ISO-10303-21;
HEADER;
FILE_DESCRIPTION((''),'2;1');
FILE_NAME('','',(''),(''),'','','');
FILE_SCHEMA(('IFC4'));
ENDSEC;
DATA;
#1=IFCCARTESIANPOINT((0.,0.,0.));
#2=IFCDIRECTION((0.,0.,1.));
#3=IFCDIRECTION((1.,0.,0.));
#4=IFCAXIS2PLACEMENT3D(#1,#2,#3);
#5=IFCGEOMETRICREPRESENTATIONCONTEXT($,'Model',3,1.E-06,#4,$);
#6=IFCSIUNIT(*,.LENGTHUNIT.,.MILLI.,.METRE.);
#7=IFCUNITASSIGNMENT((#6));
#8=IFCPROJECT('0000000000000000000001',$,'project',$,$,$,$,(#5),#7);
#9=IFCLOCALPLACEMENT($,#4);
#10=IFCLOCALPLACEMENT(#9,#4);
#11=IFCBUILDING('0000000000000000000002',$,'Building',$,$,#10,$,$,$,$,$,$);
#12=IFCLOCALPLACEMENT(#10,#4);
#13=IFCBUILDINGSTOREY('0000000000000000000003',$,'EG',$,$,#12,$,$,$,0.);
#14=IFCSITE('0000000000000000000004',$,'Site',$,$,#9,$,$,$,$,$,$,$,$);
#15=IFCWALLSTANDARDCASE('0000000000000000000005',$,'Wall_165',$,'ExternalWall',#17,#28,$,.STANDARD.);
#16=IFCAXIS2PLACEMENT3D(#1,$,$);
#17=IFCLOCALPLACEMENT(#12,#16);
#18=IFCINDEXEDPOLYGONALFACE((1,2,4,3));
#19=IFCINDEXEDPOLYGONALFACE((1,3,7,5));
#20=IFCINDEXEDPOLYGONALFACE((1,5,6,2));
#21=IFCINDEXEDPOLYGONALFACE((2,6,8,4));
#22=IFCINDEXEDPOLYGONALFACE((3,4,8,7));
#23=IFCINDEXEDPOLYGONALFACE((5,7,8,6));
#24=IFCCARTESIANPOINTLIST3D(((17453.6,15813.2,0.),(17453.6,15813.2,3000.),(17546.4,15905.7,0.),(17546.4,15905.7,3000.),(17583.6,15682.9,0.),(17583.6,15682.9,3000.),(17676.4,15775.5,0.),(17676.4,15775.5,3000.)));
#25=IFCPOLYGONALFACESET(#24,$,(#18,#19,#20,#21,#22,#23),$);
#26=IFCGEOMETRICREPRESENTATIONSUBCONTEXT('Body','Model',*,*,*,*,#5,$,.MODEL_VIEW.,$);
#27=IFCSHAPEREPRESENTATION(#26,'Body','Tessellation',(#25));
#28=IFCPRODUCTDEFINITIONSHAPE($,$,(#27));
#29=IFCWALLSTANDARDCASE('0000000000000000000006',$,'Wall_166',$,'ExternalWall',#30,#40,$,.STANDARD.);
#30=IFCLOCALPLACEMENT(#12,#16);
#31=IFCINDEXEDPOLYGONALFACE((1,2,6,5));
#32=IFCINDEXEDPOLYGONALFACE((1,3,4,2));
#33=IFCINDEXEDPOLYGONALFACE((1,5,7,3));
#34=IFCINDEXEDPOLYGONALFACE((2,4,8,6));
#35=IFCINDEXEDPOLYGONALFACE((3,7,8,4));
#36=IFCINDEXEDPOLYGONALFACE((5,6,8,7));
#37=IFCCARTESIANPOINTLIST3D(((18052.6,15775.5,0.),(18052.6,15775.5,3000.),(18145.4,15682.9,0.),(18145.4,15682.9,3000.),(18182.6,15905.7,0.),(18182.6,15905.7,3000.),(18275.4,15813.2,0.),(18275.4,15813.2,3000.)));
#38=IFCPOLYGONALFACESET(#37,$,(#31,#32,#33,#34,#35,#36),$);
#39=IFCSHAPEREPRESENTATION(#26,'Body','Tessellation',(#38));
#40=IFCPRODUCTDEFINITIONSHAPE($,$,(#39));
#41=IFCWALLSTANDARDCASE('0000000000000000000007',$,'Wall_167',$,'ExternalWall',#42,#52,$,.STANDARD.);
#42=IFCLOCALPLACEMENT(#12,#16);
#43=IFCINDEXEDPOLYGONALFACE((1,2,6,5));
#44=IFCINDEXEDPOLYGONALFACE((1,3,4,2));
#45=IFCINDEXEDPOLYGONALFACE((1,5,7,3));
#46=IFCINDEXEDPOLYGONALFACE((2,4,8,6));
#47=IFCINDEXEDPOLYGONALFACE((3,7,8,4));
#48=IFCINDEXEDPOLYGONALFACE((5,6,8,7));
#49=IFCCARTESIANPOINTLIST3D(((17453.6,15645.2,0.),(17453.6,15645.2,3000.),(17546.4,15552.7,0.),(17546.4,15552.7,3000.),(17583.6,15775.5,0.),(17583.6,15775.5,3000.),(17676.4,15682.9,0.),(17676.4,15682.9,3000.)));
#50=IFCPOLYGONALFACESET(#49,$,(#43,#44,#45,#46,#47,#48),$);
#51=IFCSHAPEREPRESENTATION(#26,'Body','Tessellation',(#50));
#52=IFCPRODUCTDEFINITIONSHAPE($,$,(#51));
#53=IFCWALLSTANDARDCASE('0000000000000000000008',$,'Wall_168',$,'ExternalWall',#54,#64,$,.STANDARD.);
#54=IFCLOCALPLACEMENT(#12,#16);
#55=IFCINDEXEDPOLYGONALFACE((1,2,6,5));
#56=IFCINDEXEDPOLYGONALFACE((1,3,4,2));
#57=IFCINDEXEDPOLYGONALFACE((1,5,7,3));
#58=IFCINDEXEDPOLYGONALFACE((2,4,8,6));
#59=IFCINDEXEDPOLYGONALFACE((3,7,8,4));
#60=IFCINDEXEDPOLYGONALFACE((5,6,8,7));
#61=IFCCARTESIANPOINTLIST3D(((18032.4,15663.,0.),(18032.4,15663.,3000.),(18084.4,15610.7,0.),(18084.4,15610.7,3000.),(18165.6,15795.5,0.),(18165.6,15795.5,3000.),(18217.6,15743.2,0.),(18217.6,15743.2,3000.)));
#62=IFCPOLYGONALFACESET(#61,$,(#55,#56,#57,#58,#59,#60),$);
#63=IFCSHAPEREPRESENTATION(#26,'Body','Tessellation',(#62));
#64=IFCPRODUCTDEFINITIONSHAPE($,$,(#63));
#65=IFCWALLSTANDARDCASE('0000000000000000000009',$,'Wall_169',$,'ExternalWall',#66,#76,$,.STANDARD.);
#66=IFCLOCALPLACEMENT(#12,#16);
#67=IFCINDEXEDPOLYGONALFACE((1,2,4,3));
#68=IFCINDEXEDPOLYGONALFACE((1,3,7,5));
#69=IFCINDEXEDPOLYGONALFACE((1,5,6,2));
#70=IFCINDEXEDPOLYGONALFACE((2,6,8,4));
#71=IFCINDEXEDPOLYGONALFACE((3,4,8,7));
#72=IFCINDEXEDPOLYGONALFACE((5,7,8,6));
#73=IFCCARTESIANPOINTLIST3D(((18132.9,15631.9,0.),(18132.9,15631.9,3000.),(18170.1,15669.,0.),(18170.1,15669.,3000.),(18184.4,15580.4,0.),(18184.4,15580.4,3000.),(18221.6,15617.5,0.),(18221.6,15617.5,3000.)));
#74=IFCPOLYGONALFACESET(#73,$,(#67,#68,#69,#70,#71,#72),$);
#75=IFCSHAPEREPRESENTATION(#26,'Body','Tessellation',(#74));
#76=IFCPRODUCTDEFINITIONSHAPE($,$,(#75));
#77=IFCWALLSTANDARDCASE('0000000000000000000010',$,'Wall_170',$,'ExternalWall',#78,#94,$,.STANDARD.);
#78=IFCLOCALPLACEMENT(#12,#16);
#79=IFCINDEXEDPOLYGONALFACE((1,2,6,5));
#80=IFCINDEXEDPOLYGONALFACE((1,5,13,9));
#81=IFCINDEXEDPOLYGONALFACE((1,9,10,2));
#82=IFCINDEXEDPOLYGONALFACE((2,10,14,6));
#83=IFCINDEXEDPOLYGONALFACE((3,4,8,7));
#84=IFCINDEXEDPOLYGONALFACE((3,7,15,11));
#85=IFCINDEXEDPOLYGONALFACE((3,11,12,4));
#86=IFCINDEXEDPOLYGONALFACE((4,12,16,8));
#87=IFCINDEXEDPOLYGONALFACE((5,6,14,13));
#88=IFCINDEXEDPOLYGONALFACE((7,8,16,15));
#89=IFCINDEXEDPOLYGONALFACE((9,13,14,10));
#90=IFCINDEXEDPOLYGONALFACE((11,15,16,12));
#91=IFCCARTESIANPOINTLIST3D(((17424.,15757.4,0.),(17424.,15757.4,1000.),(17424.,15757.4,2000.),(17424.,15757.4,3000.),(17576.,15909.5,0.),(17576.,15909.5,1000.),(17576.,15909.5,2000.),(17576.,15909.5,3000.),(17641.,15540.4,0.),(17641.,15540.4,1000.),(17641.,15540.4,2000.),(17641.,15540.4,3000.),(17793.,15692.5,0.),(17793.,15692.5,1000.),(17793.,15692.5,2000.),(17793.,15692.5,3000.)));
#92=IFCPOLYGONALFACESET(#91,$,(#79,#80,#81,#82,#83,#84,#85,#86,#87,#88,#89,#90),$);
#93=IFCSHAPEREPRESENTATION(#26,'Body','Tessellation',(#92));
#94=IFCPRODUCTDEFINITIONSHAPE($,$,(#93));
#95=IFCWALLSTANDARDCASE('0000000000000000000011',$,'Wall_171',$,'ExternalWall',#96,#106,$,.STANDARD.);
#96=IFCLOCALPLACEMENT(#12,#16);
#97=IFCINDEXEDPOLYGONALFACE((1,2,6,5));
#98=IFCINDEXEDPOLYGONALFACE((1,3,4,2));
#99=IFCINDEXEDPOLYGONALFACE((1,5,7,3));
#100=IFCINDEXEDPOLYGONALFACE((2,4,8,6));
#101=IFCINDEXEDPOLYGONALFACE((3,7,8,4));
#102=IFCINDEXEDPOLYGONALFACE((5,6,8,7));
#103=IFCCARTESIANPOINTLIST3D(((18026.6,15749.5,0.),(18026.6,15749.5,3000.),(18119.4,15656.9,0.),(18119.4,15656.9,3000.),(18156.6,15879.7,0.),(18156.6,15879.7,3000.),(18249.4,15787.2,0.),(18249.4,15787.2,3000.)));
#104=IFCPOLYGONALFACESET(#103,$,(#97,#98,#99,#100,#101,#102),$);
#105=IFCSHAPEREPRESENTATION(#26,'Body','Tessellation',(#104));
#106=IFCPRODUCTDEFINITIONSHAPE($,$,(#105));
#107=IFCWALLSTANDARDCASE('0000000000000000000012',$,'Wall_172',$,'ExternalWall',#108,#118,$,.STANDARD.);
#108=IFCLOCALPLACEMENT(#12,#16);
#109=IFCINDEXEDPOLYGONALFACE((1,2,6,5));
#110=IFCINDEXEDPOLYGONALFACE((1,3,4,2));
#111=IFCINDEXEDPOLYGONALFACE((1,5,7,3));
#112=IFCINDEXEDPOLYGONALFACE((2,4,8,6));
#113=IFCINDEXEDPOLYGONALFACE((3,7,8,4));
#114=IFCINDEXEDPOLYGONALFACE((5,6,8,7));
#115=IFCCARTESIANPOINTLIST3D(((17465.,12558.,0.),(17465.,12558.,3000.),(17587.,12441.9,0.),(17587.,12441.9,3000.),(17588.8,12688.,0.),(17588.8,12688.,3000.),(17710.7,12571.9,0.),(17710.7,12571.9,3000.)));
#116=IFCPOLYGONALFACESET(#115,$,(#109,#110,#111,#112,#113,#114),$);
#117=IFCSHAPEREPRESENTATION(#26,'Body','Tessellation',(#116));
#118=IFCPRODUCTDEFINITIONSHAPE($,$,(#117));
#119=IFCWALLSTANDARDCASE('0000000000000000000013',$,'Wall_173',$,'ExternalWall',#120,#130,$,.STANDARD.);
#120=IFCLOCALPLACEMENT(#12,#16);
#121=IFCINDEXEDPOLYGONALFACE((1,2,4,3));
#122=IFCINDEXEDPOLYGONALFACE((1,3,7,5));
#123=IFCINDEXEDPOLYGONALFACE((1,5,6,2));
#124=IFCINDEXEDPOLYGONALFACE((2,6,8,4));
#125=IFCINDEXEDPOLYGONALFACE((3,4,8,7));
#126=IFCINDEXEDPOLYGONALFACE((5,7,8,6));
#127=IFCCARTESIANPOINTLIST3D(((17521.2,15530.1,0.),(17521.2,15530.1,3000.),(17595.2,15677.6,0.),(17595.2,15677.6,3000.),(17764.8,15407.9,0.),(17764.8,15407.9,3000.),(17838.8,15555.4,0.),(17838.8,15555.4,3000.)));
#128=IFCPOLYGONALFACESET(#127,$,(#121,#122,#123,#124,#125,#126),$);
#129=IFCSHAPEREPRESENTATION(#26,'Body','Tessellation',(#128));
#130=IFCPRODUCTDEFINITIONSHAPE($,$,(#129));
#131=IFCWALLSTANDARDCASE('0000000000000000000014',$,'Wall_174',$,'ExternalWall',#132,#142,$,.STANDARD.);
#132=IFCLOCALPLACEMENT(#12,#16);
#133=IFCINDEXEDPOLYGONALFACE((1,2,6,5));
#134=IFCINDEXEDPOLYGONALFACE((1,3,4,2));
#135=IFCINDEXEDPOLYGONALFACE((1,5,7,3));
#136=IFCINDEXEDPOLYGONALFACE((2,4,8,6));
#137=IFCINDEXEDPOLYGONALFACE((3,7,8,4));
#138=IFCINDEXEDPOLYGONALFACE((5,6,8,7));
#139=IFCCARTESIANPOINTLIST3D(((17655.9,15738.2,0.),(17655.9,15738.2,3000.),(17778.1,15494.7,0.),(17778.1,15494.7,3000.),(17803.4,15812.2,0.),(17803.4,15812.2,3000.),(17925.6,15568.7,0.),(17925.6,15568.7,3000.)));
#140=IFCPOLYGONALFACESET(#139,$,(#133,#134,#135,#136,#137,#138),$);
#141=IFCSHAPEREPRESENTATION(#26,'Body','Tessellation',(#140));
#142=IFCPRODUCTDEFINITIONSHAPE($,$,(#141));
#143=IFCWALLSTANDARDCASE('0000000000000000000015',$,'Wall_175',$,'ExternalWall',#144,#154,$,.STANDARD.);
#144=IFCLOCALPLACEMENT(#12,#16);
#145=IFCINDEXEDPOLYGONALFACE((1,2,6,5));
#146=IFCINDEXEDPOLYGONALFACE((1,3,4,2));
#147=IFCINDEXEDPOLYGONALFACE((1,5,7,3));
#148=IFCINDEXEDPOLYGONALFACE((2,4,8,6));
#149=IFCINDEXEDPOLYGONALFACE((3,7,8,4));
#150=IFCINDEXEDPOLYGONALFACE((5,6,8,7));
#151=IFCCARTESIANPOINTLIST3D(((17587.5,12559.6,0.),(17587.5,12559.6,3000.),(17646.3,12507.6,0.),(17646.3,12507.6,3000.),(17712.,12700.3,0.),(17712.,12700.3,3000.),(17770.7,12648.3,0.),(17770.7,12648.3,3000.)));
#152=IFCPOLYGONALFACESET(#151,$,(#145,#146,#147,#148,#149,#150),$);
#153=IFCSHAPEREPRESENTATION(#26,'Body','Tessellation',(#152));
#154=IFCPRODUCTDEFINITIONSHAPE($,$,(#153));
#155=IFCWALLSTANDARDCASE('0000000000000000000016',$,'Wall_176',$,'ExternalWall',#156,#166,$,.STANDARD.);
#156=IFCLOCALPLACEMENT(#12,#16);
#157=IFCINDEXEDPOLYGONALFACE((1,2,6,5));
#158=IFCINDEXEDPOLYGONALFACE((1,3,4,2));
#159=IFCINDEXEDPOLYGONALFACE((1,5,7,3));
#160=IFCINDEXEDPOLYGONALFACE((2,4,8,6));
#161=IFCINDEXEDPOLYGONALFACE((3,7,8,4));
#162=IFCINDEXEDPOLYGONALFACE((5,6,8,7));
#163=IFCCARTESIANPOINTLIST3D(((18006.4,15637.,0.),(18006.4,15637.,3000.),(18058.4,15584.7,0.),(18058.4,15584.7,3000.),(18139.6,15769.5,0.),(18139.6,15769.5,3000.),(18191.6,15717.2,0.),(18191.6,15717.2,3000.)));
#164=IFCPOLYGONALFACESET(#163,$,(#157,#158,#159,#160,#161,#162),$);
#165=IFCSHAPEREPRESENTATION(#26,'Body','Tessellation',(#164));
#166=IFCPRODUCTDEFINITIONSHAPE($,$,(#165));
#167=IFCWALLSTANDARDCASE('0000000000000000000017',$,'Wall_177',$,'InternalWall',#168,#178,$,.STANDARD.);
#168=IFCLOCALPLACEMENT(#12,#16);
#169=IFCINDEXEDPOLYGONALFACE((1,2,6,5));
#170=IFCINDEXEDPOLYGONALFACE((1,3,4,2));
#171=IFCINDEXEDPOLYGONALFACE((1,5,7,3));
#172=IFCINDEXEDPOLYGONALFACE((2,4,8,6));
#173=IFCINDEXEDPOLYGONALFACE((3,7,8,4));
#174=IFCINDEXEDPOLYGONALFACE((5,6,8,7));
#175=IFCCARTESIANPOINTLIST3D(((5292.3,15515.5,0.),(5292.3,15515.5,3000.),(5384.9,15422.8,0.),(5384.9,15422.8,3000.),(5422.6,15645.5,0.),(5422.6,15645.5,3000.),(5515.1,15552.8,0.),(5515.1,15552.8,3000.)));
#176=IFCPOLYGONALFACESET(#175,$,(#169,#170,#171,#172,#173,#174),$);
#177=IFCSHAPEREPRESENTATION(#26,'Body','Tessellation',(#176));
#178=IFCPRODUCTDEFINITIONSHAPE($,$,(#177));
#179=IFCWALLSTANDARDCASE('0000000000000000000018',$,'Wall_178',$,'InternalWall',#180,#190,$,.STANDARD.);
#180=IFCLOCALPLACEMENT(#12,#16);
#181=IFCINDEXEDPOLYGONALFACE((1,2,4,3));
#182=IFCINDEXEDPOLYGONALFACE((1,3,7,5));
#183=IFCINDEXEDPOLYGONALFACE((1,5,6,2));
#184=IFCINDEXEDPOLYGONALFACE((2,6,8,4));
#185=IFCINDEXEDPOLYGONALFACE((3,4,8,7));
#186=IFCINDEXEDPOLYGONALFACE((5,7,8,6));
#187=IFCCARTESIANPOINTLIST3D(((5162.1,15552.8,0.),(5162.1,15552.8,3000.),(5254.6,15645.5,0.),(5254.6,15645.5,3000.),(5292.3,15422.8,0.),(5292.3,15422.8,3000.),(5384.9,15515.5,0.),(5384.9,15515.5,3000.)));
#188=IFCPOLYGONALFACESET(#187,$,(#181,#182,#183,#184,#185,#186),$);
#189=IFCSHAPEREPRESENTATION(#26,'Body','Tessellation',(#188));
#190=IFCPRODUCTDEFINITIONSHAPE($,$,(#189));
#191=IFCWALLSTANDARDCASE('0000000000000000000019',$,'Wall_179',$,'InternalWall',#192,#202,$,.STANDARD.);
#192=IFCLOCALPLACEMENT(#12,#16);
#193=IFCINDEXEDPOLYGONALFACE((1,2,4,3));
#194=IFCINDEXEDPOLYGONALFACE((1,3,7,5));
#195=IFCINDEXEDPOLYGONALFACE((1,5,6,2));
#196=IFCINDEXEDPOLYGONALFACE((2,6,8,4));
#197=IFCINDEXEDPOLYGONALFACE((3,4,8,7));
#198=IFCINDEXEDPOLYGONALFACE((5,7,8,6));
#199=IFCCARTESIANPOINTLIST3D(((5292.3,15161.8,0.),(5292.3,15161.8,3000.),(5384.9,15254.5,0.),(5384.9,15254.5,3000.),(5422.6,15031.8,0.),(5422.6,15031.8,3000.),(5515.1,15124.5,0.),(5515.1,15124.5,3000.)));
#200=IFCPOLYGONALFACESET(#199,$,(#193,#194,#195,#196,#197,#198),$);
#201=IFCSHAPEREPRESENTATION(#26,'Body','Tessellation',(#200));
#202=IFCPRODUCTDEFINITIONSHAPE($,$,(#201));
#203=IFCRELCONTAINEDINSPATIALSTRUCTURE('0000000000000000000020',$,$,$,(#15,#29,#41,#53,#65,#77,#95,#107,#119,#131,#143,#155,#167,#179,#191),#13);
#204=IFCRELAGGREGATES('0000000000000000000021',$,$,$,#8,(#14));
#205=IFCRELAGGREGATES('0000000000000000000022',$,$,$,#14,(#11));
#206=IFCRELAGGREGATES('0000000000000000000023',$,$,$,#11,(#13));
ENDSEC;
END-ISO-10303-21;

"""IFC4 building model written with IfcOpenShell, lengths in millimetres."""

from ifc_helpers import new_model, si_unit, frame, origin_with_axes, place, context, subcontext, project, spatial, rectangle, extrude, element, save


model = new_model("IFC4")

# Units and contexts
model_context = context("Model", 3, precision=1e-06, world=origin_with_axes())
body_context = subcontext(model_context, "Body", "Model", "MODEL_VIEW")
ifc_project = project(units=[si_unit("LENGTHUNIT", "METRE", prefix="MILLI")], contexts=[model_context])

# Site, building, storey
site_placement = place(None, origin_with_axes())
site = spatial("IfcSite", under=ifc_project, at=site_placement, Name="Site")
building_placement = place(site_placement, origin_with_axes())
building = spatial("IfcBuilding", under=site, at=building_placement, Name="Building")
storey_placement = place(building_placement, origin_with_axes())
storey = spatial("IfcBuildingStorey", under=building, at=storey_placement, Name="EG", Elevation=0.0)

# Walls
wall_1_placement = place(storey_placement, origin_with_axes())
element("IfcWallStandardCase", 1, at=wall_1_placement, inside=storey, Name="Wall_165", ObjectType="ExternalWall", PredefinedType="STANDARD", context=body_context, shape_type="SweptSolid", body=[
    extrude(rectangle(XDim=184.0, YDim=131.0), frame((17565.0, 15794.3, 0.0), z_axis=(0.0, 0.0, 1.0), x_axis=(0.706427, -0.707786, 0.0)), (0.0, 0.0, 1.0), 3000.0),
])
wall_2_placement = place(storey_placement, origin_with_axes())
element("IfcWallStandardCase", 2, at=wall_2_placement, inside=storey, Name="Wall_166", ObjectType="ExternalWall", PredefinedType="STANDARD", context=body_context, shape_type="SweptSolid", body=[
    extrude(rectangle(XDim=184.0, YDim=131.0), frame((18164.0, 15794.3, 0.0), z_axis=(0.0, 0.0, 1.0), x_axis=(0.706427, 0.707786, 0.0)), (0.0, 0.0, 1.0), 3000.0),
])
wall_3_placement = place(storey_placement, origin_with_axes())
element("IfcWallStandardCase", 3, at=wall_3_placement, inside=storey, Name="Wall_167", ObjectType="ExternalWall", PredefinedType="STANDARD", context=body_context, shape_type="SweptSolid", body=[
    extrude(rectangle(XDim=184.0, YDim=131.0), frame((17565.0, 15664.1, 0.0), z_axis=(0.0, 0.0, 1.0), x_axis=(-0.706427, -0.707786, 0.0)), (0.0, 0.0, 1.0), 3000.0),
])
wall_4_placement = place(storey_placement, origin_with_axes())
element("IfcWallStandardCase", 4, at=wall_4_placement, inside=storey, Name="Wall_168", ObjectType="ExternalWall", PredefinedType="STANDARD", context=body_context, shape_type="SweptSolid", body=[
    extrude(rectangle(XDim=73.7, YDim=187.8), frame((18125.0, 15703.1, 0.0), z_axis=(0.0, 0.0, 1.0), x_axis=(0.705409, -0.7088, 0.0)), (0.0, 0.0, 1.0), 3000.0),
])
wall_5_placement = place(storey_placement, origin_with_axes())
element("IfcWallStandardCase", 5, at=wall_5_placement, inside=storey, Name="Wall_169", ObjectType="ExternalWall", PredefinedType="STANDARD", context=body_context, shape_type="SweptSolid", body=[
    extrude(rectangle(XDim=72.8, YDim=52.5), frame((18177.3, 15624.7, 0.0), z_axis=(0.0, 0.0, 1.0), x_axis=(0.707107, -0.707107, 0.0)), (0.0, 0.0, 1.0), 3000.0),
])

# Wall, opening
wall_6_placement = place(storey_placement, origin_with_axes())
wall_6 = element("IfcWallStandardCase", 6, at=wall_6_placement, inside=storey, Name="Wall_170", ObjectType="ExternalWall", PredefinedType="STANDARD", context=body_context, shape_type="SweptSolid", body=[
    extrude(rectangle(XDim=306.9, YDim=215.0), frame((17608.5, 15725.0, 0.0), z_axis=(0.0, 0.0, 1.0), x_axis=(-0.707107, 0.707107, 0.0)), (0.0, 0.0, 1.0), 3000.0),
])
opening_placement = place(wall_6_placement, origin_with_axes())
element("IfcOpeningElement", 7, at=opening_placement, inside=storey, cuts=wall_6, context=body_context, shape_type="SweptSolid", body=[
    extrude(rectangle(XDim=600.0, YDim=215.0), frame((17545.6, 15787.9, 1000.0), z_axis=(0.0, 0.0, 1.0), x_axis=(-0.707107, 0.707107, 0.0)), (0.0, 0.0, 1.0), 1000.0),
])

# Walls
wall_7_placement = place(storey_placement, origin_with_axes())
element("IfcWallStandardCase", 8, at=wall_7_placement, inside=storey, Name="Wall_171", ObjectType="ExternalWall", PredefinedType="STANDARD", context=body_context, shape_type="SweptSolid", body=[
    extrude(rectangle(XDim=184.0, YDim=131.0), frame((18138.0, 15768.3, 0.0), z_axis=(0.0, 0.0, 1.0), x_axis=(0.706427, 0.707786, 0.0)), (0.0, 0.0, 1.0), 3000.0),
])
wall_8_placement = place(storey_placement, origin_with_axes())
element("IfcWallStandardCase", 9, at=wall_8_placement, inside=storey, Name="Wall_172", ObjectType="ExternalWall", PredefinedType="STANDARD", context=body_context, shape_type="SweptSolid", body=[
    extrude(rectangle(XDim=179.5, YDim=168.4), frame((17587.9, 12565.0, 0.0), z_axis=(0.0, 0.0, 1.0), x_axis=(-0.689481, -0.724304, 0.0)), (0.0, 0.0, 1.0), 3000.0),
])
wall_9_placement = place(storey_placement, origin_with_axes())
element("IfcWallStandardCase", 10, at=wall_9_placement, inside=storey, Name="Wall_173", ObjectType="ExternalWall", PredefinedType="STANDARD", context=body_context, shape_type="SweptSolid", body=[
    extrude(rectangle(XDim=165.0, YDim=272.5), frame((17680.0, 15542.7, 0.0), z_axis=(0.0, 0.0, 1.0), x_axis=(0.448425, 0.89382, 0.0)), (0.0, 0.0, 1.0), 3000.0),
])
wall_10_placement = place(storey_placement, origin_with_axes())
element("IfcWallStandardCase", 11, at=wall_10_placement, inside=storey, Name="Wall_174", ObjectType="ExternalWall", PredefinedType="STANDARD", context=body_context, shape_type="SweptSolid", body=[
    extrude(rectangle(XDim=165.0, YDim=272.3), frame((17790.8, 15653.5, 0.0), z_axis=(0.0, 0.0, 1.0), x_axis=(0.89382, 0.448425, 0.0)), (0.0, 0.0, 1.0), 3000.0),
])
wall_11_placement = place(storey_placement, origin_with_axes())
element("IfcWallStandardCase", 12, at=wall_11_placement, inside=storey, Name="Wall_175", ObjectType="ExternalWall", PredefinedType="STANDARD", context=body_context, shape_type="SweptSolid", body=[
    extrude(rectangle(XDim=78.5, YDim=187.8), frame((17679.1, 12604.0, 0.0), z_axis=(0.0, 0.0, 1.0), x_axis=(0.748814, -0.66278, 0.0)), (0.0, 0.0, 1.0), 3000.0),
])
wall_12_placement = place(storey_placement, origin_with_axes())
element("IfcWallStandardCase", 13, at=wall_12_placement, inside=storey, Name="Wall_176", ObjectType="ExternalWall", PredefinedType="STANDARD", context=body_context, shape_type="SweptSolid", body=[
    extrude(rectangle(XDim=73.7, YDim=187.8), frame((18099.0, 15677.1, 0.0), z_axis=(0.0, 0.0, 1.0), x_axis=(0.705409, -0.7088, 0.0)), (0.0, 0.0, 1.0), 3000.0),
])
wall_13_placement = place(storey_placement, origin_with_axes())
element("IfcWallStandardCase", 14, at=wall_13_placement, inside=storey, Name="Wall_177", ObjectType="InternalWall", PredefinedType="STANDARD", context=body_context, shape_type="SweptSolid", body=[
    extrude(rectangle(XDim=184.0, YDim=131.0), frame((5403.7, 15534.1, 0.0), z_axis=(0.0, 0.0, 1.0), x_axis=(-0.707786, -0.706427, 0.0)), (0.0, 0.0, 1.0), 3000.0),
])
wall_14_placement = place(storey_placement, origin_with_axes())
element("IfcWallStandardCase", 15, at=wall_14_placement, inside=storey, Name="Wall_178", ObjectType="InternalWall", PredefinedType="STANDARD", context=body_context, shape_type="SweptSolid", body=[
    extrude(rectangle(XDim=184.0, YDim=131.0), frame((5273.5, 15534.1, 0.0), z_axis=(0.0, 0.0, 1.0), x_axis=(-0.707786, 0.706427, 0.0)), (0.0, 0.0, 1.0), 3000.0),
])
wall_15_placement = place(storey_placement, origin_with_axes())
element("IfcWallStandardCase", 16, at=wall_15_placement, inside=storey, Name="Wall_179", ObjectType="InternalWall", PredefinedType="STANDARD", context=body_context, shape_type="SweptSolid", body=[
    extrude(rectangle(XDim=184.0, YDim=131.0), frame((5403.7, 15143.1, 0.0), z_axis=(0.0, 0.0, 1.0), x_axis=(0.707786, -0.706427, 0.0)), (0.0, 0.0, 1.0), 3000.0),
])

save(model, "model.ifc")
